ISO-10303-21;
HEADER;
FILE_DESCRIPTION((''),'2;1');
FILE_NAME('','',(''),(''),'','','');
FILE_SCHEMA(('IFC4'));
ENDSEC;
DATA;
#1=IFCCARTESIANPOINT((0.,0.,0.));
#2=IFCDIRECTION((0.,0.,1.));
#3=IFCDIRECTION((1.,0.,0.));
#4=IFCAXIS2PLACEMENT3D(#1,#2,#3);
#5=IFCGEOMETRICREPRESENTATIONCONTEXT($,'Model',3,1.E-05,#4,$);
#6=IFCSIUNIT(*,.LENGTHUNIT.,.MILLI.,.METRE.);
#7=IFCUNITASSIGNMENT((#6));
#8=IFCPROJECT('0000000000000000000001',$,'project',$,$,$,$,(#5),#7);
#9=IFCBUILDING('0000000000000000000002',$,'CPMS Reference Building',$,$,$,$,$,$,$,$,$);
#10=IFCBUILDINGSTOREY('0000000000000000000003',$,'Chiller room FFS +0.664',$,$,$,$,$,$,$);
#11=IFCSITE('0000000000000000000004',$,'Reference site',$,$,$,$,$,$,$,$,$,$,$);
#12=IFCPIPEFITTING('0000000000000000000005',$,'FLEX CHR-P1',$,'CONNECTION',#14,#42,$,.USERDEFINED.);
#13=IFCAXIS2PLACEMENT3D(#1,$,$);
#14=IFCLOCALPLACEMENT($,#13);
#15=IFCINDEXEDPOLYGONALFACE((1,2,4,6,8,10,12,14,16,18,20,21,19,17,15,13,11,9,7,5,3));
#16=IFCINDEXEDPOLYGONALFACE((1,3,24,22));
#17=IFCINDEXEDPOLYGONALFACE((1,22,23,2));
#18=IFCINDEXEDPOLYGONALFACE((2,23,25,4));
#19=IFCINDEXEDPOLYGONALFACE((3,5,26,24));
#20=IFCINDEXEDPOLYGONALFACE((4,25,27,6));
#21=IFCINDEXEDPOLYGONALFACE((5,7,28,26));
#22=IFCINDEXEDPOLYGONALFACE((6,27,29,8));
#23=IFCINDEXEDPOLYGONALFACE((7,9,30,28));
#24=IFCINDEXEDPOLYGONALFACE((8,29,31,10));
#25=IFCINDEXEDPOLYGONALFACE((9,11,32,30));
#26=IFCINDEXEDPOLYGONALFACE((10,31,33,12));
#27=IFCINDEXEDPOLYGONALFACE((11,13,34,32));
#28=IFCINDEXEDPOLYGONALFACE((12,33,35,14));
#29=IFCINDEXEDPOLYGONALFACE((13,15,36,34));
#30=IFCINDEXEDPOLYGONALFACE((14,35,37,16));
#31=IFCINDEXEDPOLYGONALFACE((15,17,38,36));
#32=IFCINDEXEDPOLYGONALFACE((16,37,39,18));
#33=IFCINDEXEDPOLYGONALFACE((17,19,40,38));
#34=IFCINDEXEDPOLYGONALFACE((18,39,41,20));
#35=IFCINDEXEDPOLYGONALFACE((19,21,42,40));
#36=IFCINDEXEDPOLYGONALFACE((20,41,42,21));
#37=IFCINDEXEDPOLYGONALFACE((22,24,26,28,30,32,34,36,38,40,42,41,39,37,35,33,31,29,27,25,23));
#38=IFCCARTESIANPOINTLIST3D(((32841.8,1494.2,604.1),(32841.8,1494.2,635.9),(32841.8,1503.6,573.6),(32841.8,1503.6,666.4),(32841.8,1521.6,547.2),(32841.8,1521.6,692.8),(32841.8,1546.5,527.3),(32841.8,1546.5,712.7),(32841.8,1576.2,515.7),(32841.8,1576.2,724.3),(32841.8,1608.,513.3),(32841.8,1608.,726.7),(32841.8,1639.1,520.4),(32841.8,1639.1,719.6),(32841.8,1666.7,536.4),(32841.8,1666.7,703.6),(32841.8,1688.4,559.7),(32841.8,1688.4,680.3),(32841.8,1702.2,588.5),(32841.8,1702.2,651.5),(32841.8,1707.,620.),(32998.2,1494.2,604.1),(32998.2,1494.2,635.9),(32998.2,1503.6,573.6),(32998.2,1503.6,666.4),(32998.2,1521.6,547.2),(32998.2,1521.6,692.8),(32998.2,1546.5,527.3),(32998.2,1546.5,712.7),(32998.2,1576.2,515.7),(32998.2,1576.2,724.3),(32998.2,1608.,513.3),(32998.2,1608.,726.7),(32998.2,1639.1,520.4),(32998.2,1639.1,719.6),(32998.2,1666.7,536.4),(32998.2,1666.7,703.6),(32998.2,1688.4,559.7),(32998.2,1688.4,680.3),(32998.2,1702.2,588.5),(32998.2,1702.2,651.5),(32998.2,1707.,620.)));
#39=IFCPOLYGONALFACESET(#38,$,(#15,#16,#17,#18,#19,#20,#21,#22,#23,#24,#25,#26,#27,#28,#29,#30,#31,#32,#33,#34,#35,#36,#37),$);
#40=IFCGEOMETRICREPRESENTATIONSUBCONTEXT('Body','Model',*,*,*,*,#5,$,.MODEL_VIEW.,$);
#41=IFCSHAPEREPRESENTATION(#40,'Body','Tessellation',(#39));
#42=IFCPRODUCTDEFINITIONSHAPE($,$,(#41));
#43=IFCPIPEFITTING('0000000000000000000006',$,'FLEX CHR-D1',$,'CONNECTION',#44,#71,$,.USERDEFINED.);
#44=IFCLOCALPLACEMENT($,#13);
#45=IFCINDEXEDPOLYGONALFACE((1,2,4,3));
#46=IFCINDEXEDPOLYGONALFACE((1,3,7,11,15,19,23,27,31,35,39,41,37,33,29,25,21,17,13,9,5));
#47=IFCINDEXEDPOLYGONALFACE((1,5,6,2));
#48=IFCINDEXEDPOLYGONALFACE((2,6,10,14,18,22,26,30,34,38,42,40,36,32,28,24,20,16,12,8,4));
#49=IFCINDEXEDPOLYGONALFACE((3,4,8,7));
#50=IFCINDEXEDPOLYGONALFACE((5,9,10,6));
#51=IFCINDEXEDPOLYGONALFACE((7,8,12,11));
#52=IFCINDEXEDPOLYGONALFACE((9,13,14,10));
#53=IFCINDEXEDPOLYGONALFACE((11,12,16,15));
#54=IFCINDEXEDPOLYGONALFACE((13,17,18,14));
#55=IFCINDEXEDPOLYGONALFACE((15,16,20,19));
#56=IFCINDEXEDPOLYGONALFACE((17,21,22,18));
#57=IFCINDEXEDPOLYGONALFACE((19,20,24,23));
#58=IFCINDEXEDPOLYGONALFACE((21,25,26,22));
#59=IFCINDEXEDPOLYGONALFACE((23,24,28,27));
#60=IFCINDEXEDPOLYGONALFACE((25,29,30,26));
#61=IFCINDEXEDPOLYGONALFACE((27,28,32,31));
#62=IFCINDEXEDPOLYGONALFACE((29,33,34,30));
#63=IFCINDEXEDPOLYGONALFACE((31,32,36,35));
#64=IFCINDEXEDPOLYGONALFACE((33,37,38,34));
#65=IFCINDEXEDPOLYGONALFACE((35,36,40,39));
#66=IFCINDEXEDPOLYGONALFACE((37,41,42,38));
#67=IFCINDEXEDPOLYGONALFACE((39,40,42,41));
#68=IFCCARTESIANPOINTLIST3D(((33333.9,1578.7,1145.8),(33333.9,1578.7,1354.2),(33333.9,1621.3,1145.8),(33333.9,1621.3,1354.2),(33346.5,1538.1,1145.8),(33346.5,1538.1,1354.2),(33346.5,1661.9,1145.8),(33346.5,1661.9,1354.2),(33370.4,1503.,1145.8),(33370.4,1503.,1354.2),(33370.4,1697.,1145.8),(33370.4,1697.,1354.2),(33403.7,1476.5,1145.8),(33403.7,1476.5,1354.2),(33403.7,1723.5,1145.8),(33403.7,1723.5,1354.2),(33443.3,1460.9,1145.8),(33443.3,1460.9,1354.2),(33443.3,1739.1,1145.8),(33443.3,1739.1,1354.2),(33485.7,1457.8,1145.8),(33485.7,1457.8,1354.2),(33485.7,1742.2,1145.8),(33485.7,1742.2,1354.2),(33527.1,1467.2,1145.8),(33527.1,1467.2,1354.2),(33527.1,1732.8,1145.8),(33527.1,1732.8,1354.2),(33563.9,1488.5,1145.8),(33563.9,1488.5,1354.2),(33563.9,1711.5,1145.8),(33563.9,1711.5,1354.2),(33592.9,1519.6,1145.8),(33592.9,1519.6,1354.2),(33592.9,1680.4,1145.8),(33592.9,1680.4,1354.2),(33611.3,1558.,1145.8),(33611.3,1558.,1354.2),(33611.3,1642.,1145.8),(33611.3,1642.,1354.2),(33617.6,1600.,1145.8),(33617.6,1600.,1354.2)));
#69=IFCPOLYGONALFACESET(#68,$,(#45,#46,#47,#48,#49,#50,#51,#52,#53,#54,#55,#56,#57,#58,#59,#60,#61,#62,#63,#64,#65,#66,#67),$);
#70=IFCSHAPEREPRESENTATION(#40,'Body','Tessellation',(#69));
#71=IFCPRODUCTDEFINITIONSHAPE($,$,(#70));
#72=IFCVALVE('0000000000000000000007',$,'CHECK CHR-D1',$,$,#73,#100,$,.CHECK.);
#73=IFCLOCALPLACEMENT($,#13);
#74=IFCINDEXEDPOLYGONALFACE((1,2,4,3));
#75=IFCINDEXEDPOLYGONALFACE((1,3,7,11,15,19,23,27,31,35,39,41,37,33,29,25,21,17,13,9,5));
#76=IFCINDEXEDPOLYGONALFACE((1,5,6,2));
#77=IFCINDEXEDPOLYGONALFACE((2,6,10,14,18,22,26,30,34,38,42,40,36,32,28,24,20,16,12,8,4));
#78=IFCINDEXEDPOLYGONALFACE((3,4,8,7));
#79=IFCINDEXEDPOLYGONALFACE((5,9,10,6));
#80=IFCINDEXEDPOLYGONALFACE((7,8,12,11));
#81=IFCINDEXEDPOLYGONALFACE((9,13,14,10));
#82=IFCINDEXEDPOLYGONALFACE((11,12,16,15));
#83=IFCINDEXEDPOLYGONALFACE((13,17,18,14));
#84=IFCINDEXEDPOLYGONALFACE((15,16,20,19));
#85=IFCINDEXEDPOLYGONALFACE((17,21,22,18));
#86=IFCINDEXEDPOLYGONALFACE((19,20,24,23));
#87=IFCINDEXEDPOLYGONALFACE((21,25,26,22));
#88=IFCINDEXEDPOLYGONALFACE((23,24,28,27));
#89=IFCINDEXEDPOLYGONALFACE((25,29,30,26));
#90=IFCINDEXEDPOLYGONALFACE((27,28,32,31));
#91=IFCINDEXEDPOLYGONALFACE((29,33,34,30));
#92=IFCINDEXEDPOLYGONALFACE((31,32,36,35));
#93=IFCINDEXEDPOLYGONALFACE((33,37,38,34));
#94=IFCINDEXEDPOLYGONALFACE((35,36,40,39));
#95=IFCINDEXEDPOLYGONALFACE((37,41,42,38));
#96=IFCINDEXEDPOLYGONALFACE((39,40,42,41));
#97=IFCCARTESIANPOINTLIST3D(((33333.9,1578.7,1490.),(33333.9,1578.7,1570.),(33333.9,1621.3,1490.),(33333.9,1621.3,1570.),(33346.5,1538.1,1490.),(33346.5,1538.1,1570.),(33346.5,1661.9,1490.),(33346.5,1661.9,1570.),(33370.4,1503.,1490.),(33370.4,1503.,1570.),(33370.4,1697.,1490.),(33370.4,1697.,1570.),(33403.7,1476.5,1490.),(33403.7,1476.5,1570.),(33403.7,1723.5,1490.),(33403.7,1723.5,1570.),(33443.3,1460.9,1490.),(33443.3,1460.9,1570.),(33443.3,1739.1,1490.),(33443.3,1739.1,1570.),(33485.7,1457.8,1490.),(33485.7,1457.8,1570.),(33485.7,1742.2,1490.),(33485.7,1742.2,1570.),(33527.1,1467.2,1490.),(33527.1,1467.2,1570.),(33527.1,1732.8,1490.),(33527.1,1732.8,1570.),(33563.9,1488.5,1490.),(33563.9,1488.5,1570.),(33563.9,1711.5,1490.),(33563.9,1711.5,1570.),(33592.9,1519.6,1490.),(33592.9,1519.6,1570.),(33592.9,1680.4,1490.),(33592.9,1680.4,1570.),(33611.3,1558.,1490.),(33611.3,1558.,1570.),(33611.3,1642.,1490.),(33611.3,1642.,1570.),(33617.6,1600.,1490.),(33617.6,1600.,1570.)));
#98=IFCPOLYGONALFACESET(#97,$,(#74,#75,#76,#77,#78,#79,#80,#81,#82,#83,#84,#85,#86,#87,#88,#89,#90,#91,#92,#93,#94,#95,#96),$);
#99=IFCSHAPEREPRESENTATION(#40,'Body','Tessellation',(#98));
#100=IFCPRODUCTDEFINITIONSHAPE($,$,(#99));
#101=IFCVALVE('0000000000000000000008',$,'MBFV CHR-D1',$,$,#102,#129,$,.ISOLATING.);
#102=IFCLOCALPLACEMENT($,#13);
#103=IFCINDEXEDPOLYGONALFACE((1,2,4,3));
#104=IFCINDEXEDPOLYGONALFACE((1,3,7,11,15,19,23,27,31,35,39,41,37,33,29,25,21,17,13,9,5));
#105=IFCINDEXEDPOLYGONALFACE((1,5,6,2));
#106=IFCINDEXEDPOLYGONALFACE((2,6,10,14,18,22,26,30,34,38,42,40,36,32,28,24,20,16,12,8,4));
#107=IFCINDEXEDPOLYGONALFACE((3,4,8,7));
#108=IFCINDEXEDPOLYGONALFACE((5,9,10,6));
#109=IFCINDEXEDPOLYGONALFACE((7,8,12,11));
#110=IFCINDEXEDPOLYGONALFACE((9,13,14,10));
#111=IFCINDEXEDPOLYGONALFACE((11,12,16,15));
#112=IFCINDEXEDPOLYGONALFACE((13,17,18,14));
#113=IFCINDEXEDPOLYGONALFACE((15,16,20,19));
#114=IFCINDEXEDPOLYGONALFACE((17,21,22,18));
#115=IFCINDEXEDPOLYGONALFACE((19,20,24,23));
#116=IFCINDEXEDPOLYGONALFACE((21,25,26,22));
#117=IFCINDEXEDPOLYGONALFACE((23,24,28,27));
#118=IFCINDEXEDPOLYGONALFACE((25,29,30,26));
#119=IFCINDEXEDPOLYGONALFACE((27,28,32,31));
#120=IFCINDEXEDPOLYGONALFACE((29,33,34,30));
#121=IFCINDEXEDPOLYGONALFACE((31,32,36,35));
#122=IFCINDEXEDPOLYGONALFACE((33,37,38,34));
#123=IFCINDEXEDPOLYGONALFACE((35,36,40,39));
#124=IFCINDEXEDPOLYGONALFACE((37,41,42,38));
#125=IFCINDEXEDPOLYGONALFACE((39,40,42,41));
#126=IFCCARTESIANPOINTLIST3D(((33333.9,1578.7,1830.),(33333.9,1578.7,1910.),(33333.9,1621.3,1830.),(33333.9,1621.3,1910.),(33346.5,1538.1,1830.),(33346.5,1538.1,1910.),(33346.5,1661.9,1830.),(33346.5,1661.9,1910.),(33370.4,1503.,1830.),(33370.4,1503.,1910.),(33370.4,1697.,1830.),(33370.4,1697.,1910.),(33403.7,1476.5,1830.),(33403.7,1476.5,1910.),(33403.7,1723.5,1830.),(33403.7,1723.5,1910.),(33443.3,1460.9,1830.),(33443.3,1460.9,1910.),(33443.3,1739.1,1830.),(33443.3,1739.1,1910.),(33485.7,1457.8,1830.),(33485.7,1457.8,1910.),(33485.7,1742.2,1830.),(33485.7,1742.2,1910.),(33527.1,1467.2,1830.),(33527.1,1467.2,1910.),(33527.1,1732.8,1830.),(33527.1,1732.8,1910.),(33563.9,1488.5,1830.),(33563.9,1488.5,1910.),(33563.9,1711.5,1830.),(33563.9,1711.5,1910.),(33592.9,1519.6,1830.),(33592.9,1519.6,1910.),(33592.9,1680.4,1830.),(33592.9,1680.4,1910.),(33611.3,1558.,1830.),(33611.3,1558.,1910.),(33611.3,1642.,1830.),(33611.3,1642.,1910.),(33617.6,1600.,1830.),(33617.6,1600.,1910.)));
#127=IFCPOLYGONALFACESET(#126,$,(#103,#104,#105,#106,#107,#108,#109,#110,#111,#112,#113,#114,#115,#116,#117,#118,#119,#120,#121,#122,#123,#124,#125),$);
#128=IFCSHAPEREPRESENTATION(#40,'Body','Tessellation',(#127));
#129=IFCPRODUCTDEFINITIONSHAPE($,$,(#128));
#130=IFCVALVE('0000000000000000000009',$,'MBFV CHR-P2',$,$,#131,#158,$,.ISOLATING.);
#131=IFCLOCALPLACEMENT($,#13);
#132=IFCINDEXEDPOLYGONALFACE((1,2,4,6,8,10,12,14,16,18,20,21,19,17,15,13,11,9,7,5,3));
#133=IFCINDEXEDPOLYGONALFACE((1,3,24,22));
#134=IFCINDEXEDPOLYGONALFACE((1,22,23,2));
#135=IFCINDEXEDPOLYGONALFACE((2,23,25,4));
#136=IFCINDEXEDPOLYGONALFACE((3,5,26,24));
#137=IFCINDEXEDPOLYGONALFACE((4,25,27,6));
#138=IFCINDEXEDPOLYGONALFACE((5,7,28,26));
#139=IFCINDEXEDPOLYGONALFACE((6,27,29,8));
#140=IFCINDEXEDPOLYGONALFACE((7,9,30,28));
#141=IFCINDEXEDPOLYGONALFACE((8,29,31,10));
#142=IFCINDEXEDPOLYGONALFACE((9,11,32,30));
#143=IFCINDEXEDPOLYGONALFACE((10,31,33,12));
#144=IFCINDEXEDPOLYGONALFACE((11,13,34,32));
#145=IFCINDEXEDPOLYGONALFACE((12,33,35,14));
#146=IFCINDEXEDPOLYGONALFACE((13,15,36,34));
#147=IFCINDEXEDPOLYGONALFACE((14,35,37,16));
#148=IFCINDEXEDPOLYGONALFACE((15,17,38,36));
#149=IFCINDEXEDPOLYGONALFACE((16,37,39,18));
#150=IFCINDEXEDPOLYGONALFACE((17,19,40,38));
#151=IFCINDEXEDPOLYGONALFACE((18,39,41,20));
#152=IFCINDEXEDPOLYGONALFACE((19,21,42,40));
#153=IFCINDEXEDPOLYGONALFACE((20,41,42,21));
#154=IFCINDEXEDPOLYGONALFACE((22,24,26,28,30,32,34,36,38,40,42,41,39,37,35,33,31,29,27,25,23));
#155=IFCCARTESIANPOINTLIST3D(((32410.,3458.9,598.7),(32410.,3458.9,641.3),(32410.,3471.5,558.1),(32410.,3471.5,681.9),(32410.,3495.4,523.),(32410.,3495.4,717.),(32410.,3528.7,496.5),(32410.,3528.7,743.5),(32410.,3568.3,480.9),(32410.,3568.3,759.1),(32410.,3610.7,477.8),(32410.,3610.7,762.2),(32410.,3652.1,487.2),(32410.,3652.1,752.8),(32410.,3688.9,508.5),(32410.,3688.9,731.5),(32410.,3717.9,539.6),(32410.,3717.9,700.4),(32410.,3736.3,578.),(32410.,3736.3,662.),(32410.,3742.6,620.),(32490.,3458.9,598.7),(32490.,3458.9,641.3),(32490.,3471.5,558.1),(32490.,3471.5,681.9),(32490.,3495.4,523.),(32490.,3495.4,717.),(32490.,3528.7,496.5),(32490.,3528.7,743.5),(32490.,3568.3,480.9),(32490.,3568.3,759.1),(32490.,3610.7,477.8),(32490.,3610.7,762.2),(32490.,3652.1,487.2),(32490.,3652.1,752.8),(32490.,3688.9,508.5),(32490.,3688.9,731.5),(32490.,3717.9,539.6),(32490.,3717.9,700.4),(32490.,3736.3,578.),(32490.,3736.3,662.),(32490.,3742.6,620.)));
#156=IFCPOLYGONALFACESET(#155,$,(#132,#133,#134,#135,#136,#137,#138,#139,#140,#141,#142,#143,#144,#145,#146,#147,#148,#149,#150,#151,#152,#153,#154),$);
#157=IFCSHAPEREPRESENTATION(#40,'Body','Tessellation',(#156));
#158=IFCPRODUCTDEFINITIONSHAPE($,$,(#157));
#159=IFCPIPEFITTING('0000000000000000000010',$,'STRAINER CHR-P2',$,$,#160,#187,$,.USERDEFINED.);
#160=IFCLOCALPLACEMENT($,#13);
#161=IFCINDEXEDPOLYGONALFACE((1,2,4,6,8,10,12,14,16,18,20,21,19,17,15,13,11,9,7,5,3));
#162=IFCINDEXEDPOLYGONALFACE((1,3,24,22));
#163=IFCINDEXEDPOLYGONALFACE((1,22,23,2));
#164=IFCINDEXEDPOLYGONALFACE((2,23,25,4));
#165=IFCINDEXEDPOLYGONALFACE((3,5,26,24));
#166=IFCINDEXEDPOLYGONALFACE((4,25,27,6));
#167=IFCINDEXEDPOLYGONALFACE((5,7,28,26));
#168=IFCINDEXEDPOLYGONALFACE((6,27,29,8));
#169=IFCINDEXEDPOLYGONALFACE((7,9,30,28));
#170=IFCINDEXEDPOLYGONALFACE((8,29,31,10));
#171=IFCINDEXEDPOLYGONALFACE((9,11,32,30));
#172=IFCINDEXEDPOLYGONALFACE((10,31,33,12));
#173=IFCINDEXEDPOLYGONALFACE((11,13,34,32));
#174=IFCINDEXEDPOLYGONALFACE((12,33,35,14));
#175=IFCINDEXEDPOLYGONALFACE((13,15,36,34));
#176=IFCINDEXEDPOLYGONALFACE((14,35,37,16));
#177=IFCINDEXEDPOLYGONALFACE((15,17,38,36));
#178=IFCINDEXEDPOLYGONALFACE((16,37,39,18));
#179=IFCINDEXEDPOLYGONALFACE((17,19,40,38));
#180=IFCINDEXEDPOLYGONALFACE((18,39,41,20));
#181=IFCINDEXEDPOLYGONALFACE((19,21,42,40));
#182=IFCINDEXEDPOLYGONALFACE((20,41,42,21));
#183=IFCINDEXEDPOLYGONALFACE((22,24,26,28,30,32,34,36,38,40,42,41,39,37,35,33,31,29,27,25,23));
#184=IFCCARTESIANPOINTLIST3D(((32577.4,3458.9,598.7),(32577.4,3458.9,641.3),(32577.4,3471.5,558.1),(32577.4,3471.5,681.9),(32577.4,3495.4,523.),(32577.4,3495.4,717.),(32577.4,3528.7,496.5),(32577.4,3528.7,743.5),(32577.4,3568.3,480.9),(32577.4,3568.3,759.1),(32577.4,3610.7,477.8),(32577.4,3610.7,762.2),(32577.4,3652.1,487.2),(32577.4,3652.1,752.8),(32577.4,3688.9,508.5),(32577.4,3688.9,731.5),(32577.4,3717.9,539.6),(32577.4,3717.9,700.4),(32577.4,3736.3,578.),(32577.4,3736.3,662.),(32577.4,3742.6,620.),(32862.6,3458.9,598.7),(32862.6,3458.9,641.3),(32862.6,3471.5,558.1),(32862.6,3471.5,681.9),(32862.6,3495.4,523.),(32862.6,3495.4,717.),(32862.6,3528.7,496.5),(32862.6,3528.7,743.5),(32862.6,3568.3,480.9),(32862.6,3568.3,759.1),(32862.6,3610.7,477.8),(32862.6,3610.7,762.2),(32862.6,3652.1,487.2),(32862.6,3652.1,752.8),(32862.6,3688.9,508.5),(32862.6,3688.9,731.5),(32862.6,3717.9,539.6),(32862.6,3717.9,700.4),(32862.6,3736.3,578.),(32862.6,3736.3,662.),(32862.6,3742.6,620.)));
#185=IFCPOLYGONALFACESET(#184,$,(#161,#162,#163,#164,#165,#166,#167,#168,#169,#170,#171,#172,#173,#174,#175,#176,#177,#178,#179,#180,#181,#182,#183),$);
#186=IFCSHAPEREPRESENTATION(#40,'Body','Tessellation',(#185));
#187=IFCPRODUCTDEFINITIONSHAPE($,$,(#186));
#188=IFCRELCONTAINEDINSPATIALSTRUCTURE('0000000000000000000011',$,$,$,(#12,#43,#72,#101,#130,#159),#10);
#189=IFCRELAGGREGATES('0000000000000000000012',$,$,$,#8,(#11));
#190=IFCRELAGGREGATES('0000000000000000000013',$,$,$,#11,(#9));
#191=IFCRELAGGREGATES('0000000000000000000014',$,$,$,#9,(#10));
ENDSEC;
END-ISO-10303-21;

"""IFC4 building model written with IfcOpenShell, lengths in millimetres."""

from ifc_helpers import new_model, si_unit, frame, origin_with_axes, origin_2d, place, context, subcontext, project, spatial, circle_curve, outline, extrude, element, save


model = new_model("IFC4")

# Units and contexts
model_context = context("Model", 3, precision=1e-05, world=origin_with_axes())
body_context = subcontext(model_context, "Body", "Model", "MODEL_VIEW")
ifc_project = project(units=[si_unit("LENGTHUNIT", "METRE", prefix="MILLI")], contexts=[model_context])

# Site, building, storey
site = spatial("IfcSite", under=ifc_project, Name="Reference site")
building = spatial("IfcBuilding", under=site, Name="CPMS Reference Building")
storey = spatial("IfcBuildingStorey", under=building, Name="Chiller room FFS +0.664")

# Pipe fittings
pipe_fitting_1_placement = place(None, origin_with_axes())
element("IfcPipeFitting", 1, at=pipe_fitting_1_placement, inside=storey, Name="FLEX CHR-P1", ObjectType="CONNECTION", PredefinedType="USERDEFINED", context=body_context, shape_type="SweptSolid", body=[
    extrude(outline(circle_curve(origin_2d(), 107.0)), frame((32841.8, 1600.0, 620.0), z_axis=(1.0, 0.0, 0.0), x_axis=(0.0, 1.0, 0.0)), (0.0, 0.0, 1.0), 156.4),
])
pipe_fitting_2_placement = place(None, origin_with_axes())
element("IfcPipeFitting", 2, at=pipe_fitting_2_placement, inside=storey, Name="FLEX CHR-D1", ObjectType="CONNECTION", PredefinedType="USERDEFINED", context=body_context, shape_type="SweptSolid", body=[
    extrude(outline(circle_curve(origin_2d(), 142.6)), frame((33475.0, 1600.0, 1145.8), z_axis=(0.0, 0.0, 1.0), x_axis=(1.0, 0.0, 0.0)), (0.0, 0.0, 1.0), 208.5),
])

# Valves
valve_1_placement = place(None, origin_with_axes())
element("IfcValve", 3, at=valve_1_placement, inside=storey, Name="CHECK CHR-D1", PredefinedType="CHECK", context=body_context, shape_type="SweptSolid", body=[
    extrude(outline(circle_curve(origin_2d(), 142.6)), frame((33475.0, 1600.0, 1490.0), z_axis=(0.0, 0.0, 1.0), x_axis=(1.0, 0.0, 0.0)), (0.0, 0.0, 1.0), 80.0),
])
valve_2_placement = place(None, origin_with_axes())
element("IfcValve", 4, at=valve_2_placement, inside=storey, Name="MBFV CHR-D1", PredefinedType="ISOLATING", context=body_context, shape_type="SweptSolid", body=[
    extrude(outline(circle_curve(origin_2d(), 142.6)), frame((33475.0, 1600.0, 1830.0), z_axis=(0.0, 0.0, 1.0), x_axis=(1.0, 0.0, 0.0)), (0.0, 0.0, 1.0), 80.0),
])
valve_3_placement = place(None, origin_with_axes())
element("IfcValve", 5, at=valve_3_placement, inside=storey, Name="MBFV CHR-P2", PredefinedType="ISOLATING", context=body_context, shape_type="SweptSolid", body=[
    extrude(outline(circle_curve(origin_2d(), 142.6)), frame((32410.0, 3600.0, 620.0), z_axis=(1.0, 0.0, 0.0), x_axis=(0.0, 1.0, 0.0)), (0.0, 0.0, 1.0), 80.0),
])

# Pipe fitting
pipe_fitting_3_placement = place(None, origin_with_axes())
element("IfcPipeFitting", 6, at=pipe_fitting_3_placement, inside=storey, Name="STRAINER CHR-P2", PredefinedType="USERDEFINED", context=body_context, shape_type="SweptSolid", body=[
    extrude(outline(circle_curve(origin_2d(), 142.6)), frame((32577.4, 3600.0, 620.0), z_axis=(1.0, 0.0, 0.0), x_axis=(0.0, 1.0, 0.0)), (0.0, 0.0, 1.0), 285.3),
])

save(model, "model.ifc")
